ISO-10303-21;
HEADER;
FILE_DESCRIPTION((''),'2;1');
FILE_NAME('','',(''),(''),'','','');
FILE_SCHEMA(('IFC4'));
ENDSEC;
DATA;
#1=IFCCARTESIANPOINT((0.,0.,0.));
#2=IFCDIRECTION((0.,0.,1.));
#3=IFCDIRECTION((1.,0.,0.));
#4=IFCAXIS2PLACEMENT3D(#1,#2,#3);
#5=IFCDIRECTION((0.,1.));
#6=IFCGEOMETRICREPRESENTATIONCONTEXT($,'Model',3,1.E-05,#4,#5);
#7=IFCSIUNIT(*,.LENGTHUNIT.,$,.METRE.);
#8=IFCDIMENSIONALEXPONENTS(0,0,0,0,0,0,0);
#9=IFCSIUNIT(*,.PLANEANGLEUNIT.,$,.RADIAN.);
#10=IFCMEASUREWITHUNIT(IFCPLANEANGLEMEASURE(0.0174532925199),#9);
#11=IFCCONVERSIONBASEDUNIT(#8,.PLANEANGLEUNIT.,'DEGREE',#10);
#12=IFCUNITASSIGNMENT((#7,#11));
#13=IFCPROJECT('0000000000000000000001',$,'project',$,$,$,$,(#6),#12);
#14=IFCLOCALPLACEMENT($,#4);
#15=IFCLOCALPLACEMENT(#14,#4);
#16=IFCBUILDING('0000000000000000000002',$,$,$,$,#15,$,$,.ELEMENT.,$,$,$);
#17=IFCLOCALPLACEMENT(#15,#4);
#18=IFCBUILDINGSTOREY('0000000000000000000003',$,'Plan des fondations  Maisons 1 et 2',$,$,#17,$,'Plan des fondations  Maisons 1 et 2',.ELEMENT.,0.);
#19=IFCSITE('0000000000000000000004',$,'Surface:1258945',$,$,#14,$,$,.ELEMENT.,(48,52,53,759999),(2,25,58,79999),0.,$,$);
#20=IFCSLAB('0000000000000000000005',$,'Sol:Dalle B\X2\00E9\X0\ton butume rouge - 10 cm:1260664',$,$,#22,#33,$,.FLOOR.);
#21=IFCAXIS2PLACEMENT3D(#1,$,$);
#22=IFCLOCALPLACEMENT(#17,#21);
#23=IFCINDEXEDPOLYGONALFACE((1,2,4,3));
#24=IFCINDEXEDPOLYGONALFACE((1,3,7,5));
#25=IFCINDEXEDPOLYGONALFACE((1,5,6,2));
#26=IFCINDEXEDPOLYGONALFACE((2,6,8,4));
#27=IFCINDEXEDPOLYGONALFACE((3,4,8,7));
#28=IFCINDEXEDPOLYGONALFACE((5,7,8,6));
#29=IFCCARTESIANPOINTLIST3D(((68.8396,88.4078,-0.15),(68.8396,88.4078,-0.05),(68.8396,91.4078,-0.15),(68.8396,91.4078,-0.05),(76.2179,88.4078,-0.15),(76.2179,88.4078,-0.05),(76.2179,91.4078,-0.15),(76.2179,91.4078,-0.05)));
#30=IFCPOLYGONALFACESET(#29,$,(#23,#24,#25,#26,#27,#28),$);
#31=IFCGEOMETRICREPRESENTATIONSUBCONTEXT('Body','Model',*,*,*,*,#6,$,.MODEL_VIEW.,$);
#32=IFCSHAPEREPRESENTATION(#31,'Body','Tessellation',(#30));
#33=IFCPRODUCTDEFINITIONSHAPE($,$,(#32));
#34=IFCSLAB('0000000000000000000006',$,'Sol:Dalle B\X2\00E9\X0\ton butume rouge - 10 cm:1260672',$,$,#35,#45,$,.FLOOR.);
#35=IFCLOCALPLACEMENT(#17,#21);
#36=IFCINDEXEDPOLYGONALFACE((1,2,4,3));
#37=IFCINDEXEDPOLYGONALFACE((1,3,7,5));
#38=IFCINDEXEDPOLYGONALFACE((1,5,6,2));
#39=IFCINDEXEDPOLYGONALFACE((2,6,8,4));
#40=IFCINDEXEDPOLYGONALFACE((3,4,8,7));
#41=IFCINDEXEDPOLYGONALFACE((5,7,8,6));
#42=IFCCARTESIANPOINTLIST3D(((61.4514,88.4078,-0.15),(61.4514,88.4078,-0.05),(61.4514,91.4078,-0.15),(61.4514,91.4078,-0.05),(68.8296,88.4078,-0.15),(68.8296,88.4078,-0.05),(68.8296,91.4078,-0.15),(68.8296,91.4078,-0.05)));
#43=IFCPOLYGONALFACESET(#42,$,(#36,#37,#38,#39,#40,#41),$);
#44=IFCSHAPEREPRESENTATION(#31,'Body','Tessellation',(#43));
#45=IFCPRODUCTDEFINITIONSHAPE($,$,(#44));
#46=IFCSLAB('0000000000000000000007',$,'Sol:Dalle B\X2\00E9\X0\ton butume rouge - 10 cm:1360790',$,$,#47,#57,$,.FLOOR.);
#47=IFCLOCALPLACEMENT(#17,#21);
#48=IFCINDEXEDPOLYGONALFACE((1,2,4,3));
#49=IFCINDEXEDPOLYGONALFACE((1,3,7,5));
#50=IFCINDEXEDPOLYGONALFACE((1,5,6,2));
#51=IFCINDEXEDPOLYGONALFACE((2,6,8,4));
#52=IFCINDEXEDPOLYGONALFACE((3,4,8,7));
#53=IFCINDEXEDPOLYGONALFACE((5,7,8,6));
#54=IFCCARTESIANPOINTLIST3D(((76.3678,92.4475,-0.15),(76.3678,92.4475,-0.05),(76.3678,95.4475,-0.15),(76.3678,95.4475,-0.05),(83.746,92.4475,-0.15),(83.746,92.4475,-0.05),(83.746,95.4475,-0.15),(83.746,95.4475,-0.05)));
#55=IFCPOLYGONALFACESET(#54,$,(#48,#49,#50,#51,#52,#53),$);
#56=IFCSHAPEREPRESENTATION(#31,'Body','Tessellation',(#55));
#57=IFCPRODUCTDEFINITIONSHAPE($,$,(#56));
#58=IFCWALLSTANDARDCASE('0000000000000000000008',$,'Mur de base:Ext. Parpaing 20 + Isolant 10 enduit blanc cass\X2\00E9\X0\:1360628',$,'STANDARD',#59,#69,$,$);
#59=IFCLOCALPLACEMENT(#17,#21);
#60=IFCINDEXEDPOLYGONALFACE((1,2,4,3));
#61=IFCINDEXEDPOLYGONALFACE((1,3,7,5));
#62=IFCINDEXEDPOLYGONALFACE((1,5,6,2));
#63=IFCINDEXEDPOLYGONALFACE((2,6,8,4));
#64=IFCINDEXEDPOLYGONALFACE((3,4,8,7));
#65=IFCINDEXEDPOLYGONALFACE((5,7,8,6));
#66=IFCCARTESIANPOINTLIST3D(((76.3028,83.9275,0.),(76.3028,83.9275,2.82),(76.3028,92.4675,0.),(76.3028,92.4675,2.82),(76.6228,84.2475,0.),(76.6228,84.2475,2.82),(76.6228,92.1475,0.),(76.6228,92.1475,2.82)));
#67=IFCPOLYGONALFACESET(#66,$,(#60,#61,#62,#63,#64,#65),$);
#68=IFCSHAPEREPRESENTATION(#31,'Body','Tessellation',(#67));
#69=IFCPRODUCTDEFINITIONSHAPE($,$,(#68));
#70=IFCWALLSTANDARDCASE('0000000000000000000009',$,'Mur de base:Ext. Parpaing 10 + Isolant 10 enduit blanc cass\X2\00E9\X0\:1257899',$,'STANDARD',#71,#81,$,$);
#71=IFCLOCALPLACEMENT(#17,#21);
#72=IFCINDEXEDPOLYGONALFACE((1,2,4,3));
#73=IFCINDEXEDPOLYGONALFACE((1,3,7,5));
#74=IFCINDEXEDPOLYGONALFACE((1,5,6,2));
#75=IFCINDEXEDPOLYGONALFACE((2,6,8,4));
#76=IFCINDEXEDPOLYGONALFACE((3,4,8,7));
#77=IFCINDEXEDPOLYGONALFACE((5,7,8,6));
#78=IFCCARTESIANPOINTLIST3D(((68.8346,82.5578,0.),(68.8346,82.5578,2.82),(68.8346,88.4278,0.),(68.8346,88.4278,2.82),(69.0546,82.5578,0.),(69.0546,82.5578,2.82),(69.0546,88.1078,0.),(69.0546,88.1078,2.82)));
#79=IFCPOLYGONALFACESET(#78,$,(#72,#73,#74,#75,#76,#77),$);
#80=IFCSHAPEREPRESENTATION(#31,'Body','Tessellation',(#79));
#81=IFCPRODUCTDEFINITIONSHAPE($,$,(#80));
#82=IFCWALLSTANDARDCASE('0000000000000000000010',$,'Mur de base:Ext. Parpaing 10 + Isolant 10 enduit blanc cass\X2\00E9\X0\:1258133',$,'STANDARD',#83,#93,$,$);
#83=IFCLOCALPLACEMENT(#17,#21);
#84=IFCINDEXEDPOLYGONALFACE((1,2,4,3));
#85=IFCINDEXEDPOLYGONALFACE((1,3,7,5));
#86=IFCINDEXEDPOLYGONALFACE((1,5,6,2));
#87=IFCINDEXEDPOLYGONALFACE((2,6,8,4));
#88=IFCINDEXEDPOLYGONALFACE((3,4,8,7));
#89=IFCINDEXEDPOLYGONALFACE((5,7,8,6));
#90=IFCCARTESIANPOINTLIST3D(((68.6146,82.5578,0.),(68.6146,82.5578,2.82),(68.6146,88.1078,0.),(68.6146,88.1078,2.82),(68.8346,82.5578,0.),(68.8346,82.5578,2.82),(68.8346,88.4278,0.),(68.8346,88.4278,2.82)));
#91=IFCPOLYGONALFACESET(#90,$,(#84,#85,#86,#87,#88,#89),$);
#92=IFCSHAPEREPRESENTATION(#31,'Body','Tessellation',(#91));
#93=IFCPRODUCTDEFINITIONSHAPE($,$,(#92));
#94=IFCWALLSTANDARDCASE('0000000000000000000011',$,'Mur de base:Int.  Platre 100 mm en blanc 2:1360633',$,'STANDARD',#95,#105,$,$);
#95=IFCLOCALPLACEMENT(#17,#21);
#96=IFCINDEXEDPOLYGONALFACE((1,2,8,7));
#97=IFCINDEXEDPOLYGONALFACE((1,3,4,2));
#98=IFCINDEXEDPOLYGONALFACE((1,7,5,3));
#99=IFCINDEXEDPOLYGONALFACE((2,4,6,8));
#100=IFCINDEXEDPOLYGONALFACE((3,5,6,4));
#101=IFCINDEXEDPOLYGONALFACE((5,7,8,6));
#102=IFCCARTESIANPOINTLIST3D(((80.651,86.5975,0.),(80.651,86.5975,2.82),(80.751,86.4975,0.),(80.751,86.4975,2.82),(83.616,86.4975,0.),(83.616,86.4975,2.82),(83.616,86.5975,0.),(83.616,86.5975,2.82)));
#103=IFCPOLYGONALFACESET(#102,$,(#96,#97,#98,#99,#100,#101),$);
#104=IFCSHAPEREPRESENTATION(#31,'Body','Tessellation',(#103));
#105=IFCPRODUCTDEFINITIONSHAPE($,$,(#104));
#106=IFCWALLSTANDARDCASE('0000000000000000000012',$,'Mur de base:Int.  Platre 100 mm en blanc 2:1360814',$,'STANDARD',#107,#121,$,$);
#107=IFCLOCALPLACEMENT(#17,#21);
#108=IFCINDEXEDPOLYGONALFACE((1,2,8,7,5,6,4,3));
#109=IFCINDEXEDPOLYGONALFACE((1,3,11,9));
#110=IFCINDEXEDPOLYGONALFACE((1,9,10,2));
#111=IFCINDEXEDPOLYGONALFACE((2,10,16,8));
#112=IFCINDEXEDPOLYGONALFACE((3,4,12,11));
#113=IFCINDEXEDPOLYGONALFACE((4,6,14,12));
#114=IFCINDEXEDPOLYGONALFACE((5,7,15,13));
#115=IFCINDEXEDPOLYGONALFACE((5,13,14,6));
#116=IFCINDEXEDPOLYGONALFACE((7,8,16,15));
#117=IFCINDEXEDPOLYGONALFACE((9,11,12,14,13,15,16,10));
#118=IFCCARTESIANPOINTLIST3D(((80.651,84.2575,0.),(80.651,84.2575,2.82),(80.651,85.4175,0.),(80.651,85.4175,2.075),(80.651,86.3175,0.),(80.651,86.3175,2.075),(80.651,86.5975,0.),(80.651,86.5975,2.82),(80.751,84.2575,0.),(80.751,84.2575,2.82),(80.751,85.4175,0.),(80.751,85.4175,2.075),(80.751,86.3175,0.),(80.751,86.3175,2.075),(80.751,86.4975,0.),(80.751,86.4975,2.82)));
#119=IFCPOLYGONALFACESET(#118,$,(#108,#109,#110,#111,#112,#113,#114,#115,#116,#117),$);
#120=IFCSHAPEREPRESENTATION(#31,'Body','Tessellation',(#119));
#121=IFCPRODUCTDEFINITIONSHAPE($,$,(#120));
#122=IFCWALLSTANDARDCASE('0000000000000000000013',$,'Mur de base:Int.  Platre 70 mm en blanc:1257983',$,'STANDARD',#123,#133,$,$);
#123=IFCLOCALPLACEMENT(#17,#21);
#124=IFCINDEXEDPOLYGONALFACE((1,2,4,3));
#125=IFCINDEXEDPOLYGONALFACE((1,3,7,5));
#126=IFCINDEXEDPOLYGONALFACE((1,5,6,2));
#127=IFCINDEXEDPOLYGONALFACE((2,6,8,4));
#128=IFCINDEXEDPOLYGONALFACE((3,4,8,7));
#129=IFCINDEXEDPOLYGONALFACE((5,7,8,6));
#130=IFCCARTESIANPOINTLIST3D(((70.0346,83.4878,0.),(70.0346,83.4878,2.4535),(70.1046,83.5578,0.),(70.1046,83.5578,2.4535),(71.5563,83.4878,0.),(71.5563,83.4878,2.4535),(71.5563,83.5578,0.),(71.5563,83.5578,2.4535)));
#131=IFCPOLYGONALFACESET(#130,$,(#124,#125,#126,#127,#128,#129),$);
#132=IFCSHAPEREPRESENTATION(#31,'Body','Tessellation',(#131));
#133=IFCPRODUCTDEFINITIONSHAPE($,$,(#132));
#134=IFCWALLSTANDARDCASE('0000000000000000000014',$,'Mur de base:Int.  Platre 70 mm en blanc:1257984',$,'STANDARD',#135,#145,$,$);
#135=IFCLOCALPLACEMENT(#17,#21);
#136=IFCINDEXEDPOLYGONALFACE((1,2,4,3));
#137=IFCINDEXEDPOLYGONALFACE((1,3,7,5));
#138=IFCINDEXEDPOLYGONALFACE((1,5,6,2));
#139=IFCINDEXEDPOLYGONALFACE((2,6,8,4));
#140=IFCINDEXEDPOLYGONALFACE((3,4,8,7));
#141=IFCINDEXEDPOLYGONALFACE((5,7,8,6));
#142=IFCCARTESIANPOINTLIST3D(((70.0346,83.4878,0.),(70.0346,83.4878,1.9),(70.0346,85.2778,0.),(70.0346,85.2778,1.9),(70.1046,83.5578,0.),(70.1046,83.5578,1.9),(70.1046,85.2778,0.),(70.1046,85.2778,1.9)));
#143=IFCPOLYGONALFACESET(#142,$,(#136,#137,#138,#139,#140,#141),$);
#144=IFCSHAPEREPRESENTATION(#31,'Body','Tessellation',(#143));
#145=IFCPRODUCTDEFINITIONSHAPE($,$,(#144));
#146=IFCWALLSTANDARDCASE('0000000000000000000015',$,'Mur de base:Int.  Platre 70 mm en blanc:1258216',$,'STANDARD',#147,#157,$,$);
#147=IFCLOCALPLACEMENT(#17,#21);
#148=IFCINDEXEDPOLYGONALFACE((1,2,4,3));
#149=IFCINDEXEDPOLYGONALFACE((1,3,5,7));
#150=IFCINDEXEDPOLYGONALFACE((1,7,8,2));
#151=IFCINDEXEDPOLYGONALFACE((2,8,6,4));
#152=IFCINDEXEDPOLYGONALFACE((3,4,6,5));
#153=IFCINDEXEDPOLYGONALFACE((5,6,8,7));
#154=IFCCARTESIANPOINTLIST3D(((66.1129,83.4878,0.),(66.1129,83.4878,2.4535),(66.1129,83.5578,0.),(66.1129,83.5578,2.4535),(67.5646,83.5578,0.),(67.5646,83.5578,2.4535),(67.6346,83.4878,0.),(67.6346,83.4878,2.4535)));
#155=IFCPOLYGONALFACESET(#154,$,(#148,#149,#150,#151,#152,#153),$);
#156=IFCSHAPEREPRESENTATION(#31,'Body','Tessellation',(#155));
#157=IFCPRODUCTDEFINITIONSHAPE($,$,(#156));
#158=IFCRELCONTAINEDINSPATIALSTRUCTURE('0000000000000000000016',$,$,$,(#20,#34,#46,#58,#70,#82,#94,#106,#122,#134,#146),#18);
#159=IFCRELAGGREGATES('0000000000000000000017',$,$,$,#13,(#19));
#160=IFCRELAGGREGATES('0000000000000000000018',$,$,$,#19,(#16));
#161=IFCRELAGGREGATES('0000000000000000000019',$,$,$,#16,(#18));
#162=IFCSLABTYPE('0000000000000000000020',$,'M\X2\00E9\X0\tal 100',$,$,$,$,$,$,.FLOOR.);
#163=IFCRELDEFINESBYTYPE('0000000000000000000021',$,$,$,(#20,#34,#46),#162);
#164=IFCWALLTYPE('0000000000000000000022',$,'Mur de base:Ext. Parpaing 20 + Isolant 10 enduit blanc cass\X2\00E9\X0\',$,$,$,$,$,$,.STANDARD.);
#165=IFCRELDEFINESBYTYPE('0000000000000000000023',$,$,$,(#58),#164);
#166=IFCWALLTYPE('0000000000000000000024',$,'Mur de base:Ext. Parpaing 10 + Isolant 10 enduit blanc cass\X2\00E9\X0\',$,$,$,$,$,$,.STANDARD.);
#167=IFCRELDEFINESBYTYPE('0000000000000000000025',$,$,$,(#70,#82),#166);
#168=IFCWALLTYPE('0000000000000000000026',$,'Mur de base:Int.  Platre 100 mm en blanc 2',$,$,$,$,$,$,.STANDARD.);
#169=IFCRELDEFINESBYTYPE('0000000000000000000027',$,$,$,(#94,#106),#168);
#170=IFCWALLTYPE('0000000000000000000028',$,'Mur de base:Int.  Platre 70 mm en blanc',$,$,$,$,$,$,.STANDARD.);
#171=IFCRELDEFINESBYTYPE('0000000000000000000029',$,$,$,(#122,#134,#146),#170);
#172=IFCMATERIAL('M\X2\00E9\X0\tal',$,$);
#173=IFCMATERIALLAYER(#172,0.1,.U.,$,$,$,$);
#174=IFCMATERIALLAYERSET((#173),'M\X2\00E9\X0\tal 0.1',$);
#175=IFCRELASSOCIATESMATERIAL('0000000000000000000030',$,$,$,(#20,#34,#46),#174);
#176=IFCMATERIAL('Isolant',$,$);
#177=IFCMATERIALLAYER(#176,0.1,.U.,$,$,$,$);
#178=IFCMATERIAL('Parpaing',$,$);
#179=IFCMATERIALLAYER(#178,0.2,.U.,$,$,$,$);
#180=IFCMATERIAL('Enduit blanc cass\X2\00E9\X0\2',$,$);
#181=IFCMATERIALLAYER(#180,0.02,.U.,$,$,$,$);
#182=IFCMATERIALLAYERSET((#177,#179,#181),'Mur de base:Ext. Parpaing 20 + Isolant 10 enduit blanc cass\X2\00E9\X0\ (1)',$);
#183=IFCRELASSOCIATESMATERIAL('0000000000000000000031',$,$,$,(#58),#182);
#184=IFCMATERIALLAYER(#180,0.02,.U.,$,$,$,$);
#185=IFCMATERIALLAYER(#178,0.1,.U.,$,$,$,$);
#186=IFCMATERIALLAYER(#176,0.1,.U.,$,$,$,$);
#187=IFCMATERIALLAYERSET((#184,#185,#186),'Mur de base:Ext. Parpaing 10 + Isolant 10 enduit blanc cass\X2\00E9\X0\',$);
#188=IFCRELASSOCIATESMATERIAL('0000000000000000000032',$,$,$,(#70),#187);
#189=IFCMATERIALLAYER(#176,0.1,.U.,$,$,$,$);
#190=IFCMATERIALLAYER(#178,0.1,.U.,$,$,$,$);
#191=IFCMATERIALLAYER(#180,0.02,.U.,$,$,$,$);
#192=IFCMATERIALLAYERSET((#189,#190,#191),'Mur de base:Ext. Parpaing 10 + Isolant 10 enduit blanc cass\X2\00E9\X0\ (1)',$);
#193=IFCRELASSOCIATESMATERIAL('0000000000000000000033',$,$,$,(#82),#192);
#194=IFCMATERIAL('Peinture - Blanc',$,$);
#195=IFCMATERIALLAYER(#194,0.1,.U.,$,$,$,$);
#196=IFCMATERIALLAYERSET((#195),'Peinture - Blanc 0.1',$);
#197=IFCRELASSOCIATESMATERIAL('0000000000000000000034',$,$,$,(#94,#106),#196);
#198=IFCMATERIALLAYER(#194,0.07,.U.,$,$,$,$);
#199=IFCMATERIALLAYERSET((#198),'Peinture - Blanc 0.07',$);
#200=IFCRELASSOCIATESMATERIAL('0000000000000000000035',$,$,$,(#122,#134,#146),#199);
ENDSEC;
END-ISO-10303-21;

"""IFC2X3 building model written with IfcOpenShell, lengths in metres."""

from ifc_helpers import new_model, entity, si_unit, converted_unit, direction, frame, origin_with_axes, place, context, subcontext, project, spatial, polyline, outline, extrude, material, layer, layer_set, layer_usage, type_object, element, save


model = new_model("IFC2X3")

# Units and contexts
model_context = context("Model", 3, precision=1e-05, world=origin_with_axes(), true_north=direction((0.0, 1.0)))
body_context = subcontext(model_context, "Body", "Model", "MODEL_VIEW")
ifc_project = project(units=[si_unit("LENGTHUNIT", "METRE"), converted_unit("PLANEANGLEUNIT", "DEGREE", entity("IfcPlaneAngleMeasure", 0.0174532925199), si_unit("PLANEANGLEUNIT", "RADIAN"), dimensions=[0, 0, 0, 0, 0, 0, 0])], contexts=[model_context])

# Site, building, storey
site_placement = place(None, origin_with_axes())
site = spatial("IfcSite", under=ifc_project, at=site_placement, Name="Surface:1258945", CompositionType="ELEMENT", RefLatitude=(48, 52, 53, 759999), RefLongitude=(2, 25, 58, 79999), RefElevation=0.0)
building_placement = place(site_placement, origin_with_axes())
building = spatial("IfcBuilding", under=site, at=building_placement, CompositionType="ELEMENT")
storey_placement = place(building_placement, origin_with_axes())
storey = spatial("IfcBuildingStorey", under=building, at=storey_placement, Name="Plan des fondations  Maisons 1 et 2", LongName="Plan des fondations  Maisons 1 et 2", CompositionType="ELEMENT", Elevation=0.0)

# Slabs
ifc_material_1 = material(Name="Métal")
ifc_layer_1 = layer(ifc_material_1, 0.1, ventilated="UNKNOWN")
ifc_layer_set_1 = layer_set([ifc_layer_1], Name="Métal 0.1")
ifc_layer_usage_1 = layer_usage(ifc_layer_set_1, "AXIS3", "NEGATIVE", 0.1)
slab_type = type_object("IfcSlabType", Name="Métal 100", PredefinedType="FLOOR")
slab_1_placement = place(storey_placement, frame((68.8396, 91.4078, -0.05), z_axis=(0.0, 0.0, 1.0), x_axis=(1.0, 0.0, 0.0)))
element("IfcSlab", 1, at=slab_1_placement, inside=storey, type_object=slab_type, material=ifc_layer_usage_1, Name="Sol:Dalle Béton butume rouge - 10 cm:1260664", PredefinedType="FLOOR", context=body_context, shape_type="SweptSolid", body=[
    extrude(outline(polyline([(0.0, 0.0), (0.0, -3.0), (7.3783, -3.0), (7.3783, 0.0), (0.0, 0.0)])), frame((0.0, 0.0, -0.1), z_axis=(0.0, 0.0, 1.0), x_axis=(1.0, 0.0, 0.0)), (0.0, 0.0, 1.0), 0.1),
])
ifc_layer_usage_2 = layer_usage(ifc_layer_set_1, "AXIS3", "NEGATIVE", 0.1)
slab_2_placement = place(storey_placement, frame((61.4514, 91.4078, -0.05), z_axis=(0.0, 0.0, 1.0), x_axis=(1.0, 0.0, 0.0)))
element("IfcSlab", 2, at=slab_2_placement, inside=storey, type_object=slab_type, material=ifc_layer_usage_2, Name="Sol:Dalle Béton butume rouge - 10 cm:1260672", PredefinedType="FLOOR", context=body_context, shape_type="SweptSolid", body=[
    extrude(outline(polyline([(0.0, 0.0), (0.0, -3.0), (7.3783, -3.0), (7.3783, 0.0), (0.0, 0.0)])), frame((0.0, 0.0, -0.1), z_axis=(0.0, 0.0, 1.0), x_axis=(1.0, 0.0, 0.0)), (0.0, 0.0, 1.0), 0.1),
])
ifc_layer_usage_3 = layer_usage(ifc_layer_set_1, "AXIS3", "NEGATIVE", 0.1)
slab_3_placement = place(storey_placement, frame((76.3678, 95.4475, -0.05), z_axis=(0.0, 0.0, 1.0), x_axis=(1.0, 0.0, 0.0)))
element("IfcSlab", 3, at=slab_3_placement, inside=storey, type_object=slab_type, material=ifc_layer_usage_3, Name="Sol:Dalle Béton butume rouge - 10 cm:1360790", PredefinedType="FLOOR", context=body_context, shape_type="SweptSolid", body=[
    extrude(outline(polyline([(0.0, 0.0), (0.0, -3.0), (7.3783, -3.0), (7.3783, 0.0), (0.0, 0.0)])), frame((0.0, 0.0, -0.1), z_axis=(0.0, 0.0, 1.0), x_axis=(1.0, 0.0, 0.0)), (0.0, 0.0, 1.0), 0.1),
])

# Walls
ifc_material_2 = material(Name="Isolant")
ifc_layer_2 = layer(ifc_material_2, 0.1, ventilated="UNKNOWN")
ifc_material_3 = material(Name="Parpaing")
ifc_layer_3 = layer(ifc_material_3, 0.2, ventilated="UNKNOWN")
ifc_material_4 = material(Name="Enduit blanc cassé2")
ifc_layer_4 = layer(ifc_material_4, 0.02, ventilated="UNKNOWN")
ifc_layer_set_2 = layer_set([ifc_layer_2, ifc_layer_3, ifc_layer_4], Name="Mur de base:Ext. Parpaing 20 + Isolant 10 enduit blanc cassé (1)")
ifc_layer_usage_4 = layer_usage(ifc_layer_set_2, "AXIS2", "POSITIVE", -0.16)
wall_type_1 = type_object("IfcWallType", Name="Mur de base:Ext. Parpaing 20 + Isolant 10 enduit blanc cassé", PredefinedType="STANDARD")
wall_1_placement = place(storey_placement, frame((76.4628, 84.0875, 0.0), z_axis=(0.0, 0.0, 1.0), x_axis=(0.0, 1.0, 0.0)))
element("IfcWallStandardCase", 4, at=wall_1_placement, inside=storey, type_object=wall_type_1, material=ifc_layer_usage_4, Name="Mur de base:Ext. Parpaing 20 + Isolant 10 enduit blanc cassé:1360628", ObjectType="STANDARD", context=body_context, shape_type="SweptSolid", body=[
    extrude(outline(polyline([(0.16, -0.16), (8.06, -0.16), (8.38, 0.16), (-0.16, 0.16), (0.16, -0.16)])), origin_with_axes(), (0.0, 0.0, 1.0), 2.82),
])
ifc_layer_5 = layer(ifc_material_4, 0.02, ventilated="UNKNOWN")
ifc_layer_6 = layer(ifc_material_3, 0.1, ventilated="UNKNOWN")
ifc_layer_7 = layer(ifc_material_2, 0.1, ventilated="UNKNOWN")
ifc_layer_set_3 = layer_set([ifc_layer_5, ifc_layer_6, ifc_layer_7], Name="Mur de base:Ext. Parpaing 10 + Isolant 10 enduit blanc cassé")
ifc_layer_usage_5 = layer_usage(ifc_layer_set_3, "AXIS2", "POSITIVE", -0.11)
wall_type_2 = type_object("IfcWallType", Name="Mur de base:Ext. Parpaing 10 + Isolant 10 enduit blanc cassé", PredefinedType="STANDARD")
wall_2_placement = place(storey_placement, frame((68.9446, 88.2678, 0.0), z_axis=(0.0, 0.0, 1.0), x_axis=(0.0, -1.0, 0.0)))
element("IfcWallStandardCase", 5, at=wall_2_placement, inside=storey, type_object=wall_type_2, material=ifc_layer_usage_5, Name="Mur de base:Ext. Parpaing 10 + Isolant 10 enduit blanc cassé:1257899", ObjectType="STANDARD", context=body_context, shape_type="SweptSolid", body=[
    extrude(outline(polyline([(-0.16, -0.11), (5.71, -0.11), (5.71, 0.11), (0.16, 0.11), (-0.16, -0.11)])), origin_with_axes(), (0.0, 0.0, 1.0), 2.82),
])
ifc_layer_8 = layer(ifc_material_2, 0.1, ventilated="UNKNOWN")
ifc_layer_9 = layer(ifc_material_3, 0.1, ventilated="UNKNOWN")
ifc_layer_10 = layer(ifc_material_4, 0.02, ventilated="UNKNOWN")
ifc_layer_set_4 = layer_set([ifc_layer_8, ifc_layer_9, ifc_layer_10], Name="Mur de base:Ext. Parpaing 10 + Isolant 10 enduit blanc cassé (1)")
ifc_layer_usage_6 = layer_usage(ifc_layer_set_4, "AXIS2", "POSITIVE", -0.11)
wall_3_placement = place(storey_placement, frame((68.7246, 88.2678, 0.0), z_axis=(0.0, 0.0, 1.0), x_axis=(0.0, -1.0, 0.0)))
element("IfcWallStandardCase", 6, at=wall_3_placement, inside=storey, type_object=wall_type_2, material=ifc_layer_usage_6, Name="Mur de base:Ext. Parpaing 10 + Isolant 10 enduit blanc cassé:1258133", ObjectType="STANDARD", context=body_context, shape_type="SweptSolid", body=[
    extrude(outline(polyline([(0.16, -0.11), (5.71, -0.11), (5.71, 0.11), (-0.16, 0.11), (0.16, -0.11)])), origin_with_axes(), (0.0, 0.0, 1.0), 2.82),
])
ifc_material_5 = material(Name="Peinture - Blanc")
ifc_layer_11 = layer(ifc_material_5, 0.1, ventilated="UNKNOWN")
ifc_layer_set_5 = layer_set([ifc_layer_11], Name="Peinture - Blanc 0.1")
ifc_layer_usage_7 = layer_usage(ifc_layer_set_5, "AXIS2", "POSITIVE", -0.05)
wall_type_3 = type_object("IfcWallType", Name="Mur de base:Int.  Platre 100 mm en blanc 2", PredefinedType="STANDARD")
wall_4_placement = place(storey_placement, frame((80.701, 86.5475, 0.0), z_axis=(0.0, 0.0, 1.0), x_axis=(1.0, 0.0, 0.0)))
element("IfcWallStandardCase", 7, at=wall_4_placement, inside=storey, type_object=wall_type_3, material=ifc_layer_usage_7, Name="Mur de base:Int.  Platre 100 mm en blanc 2:1360633", ObjectType="STANDARD", context=body_context, shape_type="SweptSolid", body=[
    extrude(outline(polyline([(0.05, -0.05), (2.915, -0.05), (2.915, 0.05), (-0.05, 0.05), (0.05, -0.05)])), origin_with_axes(), (0.0, 0.0, 1.0), 2.82),
])

# Wall, opening
ifc_layer_usage_8 = layer_usage(ifc_layer_set_5, "AXIS2", "POSITIVE", -0.05)
wall_5_placement = place(storey_placement, frame((80.701, 84.2575, 0.0), z_axis=(0.0, 0.0, 1.0), x_axis=(0.0, 1.0, 0.0)))
wall_5 = element("IfcWallStandardCase", 8, at=wall_5_placement, inside=storey, type_object=wall_type_3, material=ifc_layer_usage_8, Name="Mur de base:Int.  Platre 100 mm en blanc 2:1360814", ObjectType="STANDARD", context=body_context, shape_type="SweptSolid", body=[
    extrude(outline(polyline([(0.0, -0.05), (2.24, -0.05), (2.34, 0.05), (0.0, 0.05), (0.0, -0.05)])), origin_with_axes(), (0.0, 0.0, 1.0), 2.82),
])
opening_1_placement = place(wall_5_placement, frame((1.61, 0.0, 0.0), z_axis=(0.0, 0.0, 1.0), x_axis=(1.0, 0.0, 0.0)))
element("IfcOpeningElement", 9, at=opening_1_placement, cuts=wall_5, context=body_context, shape_type="SweptSolid", body=[
    extrude(outline(polyline([(-0.45, 0.0), (0.45, 0.0), (0.45, 2.075), (-0.45, 2.075), (-0.45, 0.0)])), frame((0.0, 0.05, 0.0), z_axis=(0.0, 1.0, 0.0), x_axis=(-1.0, 0.0, 0.0)), (0.0, 0.0, -1.0), 0.1),
])

# Walls
ifc_layer_12 = layer(ifc_material_5, 0.07, ventilated="UNKNOWN")
ifc_layer_set_6 = layer_set([ifc_layer_12], Name="Peinture - Blanc 0.07")
wall_type_4 = type_object("IfcWallType", Name="Mur de base:Int.  Platre 70 mm en blanc", PredefinedType="STANDARD")
ifc_layer_usage_9 = layer_usage(ifc_layer_set_6, "AXIS2", "POSITIVE", -0.035)
wall_6_placement = place(storey_placement, frame((70.0696, 83.5228, 0.0), z_axis=(0.0, 0.0, 1.0), x_axis=(1.0, 0.0, 0.0)))
element("IfcWallStandardCase", 10, at=wall_6_placement, inside=storey, type_object=wall_type_4, material=ifc_layer_usage_9, Name="Mur de base:Int.  Platre 70 mm en blanc:1257983", ObjectType="STANDARD", context=body_context, shape_type="SweptSolid", body=[
    extrude(outline(polyline([(-0.035, -0.035), (1.4867, -0.035), (1.4867, 0.035), (0.035, 0.035), (-0.035, -0.035)])), origin_with_axes(), (0.0, 0.0, 1.0), 2.4535),
])
ifc_layer_usage_10 = layer_usage(ifc_layer_set_6, "AXIS2", "POSITIVE", -0.035)
wall_7_placement = place(storey_placement, frame((70.0696, 83.5228, 0.0), z_axis=(0.0, 0.0, 1.0), x_axis=(0.0, 1.0, 0.0)))
element("IfcWallStandardCase", 11, at=wall_7_placement, inside=storey, type_object=wall_type_4, material=ifc_layer_usage_10, Name="Mur de base:Int.  Platre 70 mm en blanc:1257984", ObjectType="STANDARD", context=body_context, shape_type="SweptSolid", body=[
    extrude(outline(polyline([(0.035, -0.035), (1.755, -0.035), (1.755, 0.035), (-0.035, 0.035), (0.035, -0.035)])), origin_with_axes(), (0.0, 0.0, 1.0), 1.9),
])
ifc_layer_usage_11 = layer_usage(ifc_layer_set_6, "AXIS2", "POSITIVE", -0.035)
wall_8_placement = place(storey_placement, frame((67.5996, 83.5228, 0.0), z_axis=(0.0, 0.0, 1.0), x_axis=(-1.0, 0.0, 0.0)))
element("IfcWallStandardCase", 12, at=wall_8_placement, inside=storey, type_object=wall_type_4, material=ifc_layer_usage_11, Name="Mur de base:Int.  Platre 70 mm en blanc:1258216", ObjectType="STANDARD", context=body_context, shape_type="SweptSolid", body=[
    extrude(outline(polyline([(0.035, -0.035), (1.4867, -0.035), (1.4867, 0.035), (-0.035, 0.035), (0.035, -0.035)])), origin_with_axes(), (0.0, 0.0, 1.0), 2.4535),
])

save(model, "model.ifc")
